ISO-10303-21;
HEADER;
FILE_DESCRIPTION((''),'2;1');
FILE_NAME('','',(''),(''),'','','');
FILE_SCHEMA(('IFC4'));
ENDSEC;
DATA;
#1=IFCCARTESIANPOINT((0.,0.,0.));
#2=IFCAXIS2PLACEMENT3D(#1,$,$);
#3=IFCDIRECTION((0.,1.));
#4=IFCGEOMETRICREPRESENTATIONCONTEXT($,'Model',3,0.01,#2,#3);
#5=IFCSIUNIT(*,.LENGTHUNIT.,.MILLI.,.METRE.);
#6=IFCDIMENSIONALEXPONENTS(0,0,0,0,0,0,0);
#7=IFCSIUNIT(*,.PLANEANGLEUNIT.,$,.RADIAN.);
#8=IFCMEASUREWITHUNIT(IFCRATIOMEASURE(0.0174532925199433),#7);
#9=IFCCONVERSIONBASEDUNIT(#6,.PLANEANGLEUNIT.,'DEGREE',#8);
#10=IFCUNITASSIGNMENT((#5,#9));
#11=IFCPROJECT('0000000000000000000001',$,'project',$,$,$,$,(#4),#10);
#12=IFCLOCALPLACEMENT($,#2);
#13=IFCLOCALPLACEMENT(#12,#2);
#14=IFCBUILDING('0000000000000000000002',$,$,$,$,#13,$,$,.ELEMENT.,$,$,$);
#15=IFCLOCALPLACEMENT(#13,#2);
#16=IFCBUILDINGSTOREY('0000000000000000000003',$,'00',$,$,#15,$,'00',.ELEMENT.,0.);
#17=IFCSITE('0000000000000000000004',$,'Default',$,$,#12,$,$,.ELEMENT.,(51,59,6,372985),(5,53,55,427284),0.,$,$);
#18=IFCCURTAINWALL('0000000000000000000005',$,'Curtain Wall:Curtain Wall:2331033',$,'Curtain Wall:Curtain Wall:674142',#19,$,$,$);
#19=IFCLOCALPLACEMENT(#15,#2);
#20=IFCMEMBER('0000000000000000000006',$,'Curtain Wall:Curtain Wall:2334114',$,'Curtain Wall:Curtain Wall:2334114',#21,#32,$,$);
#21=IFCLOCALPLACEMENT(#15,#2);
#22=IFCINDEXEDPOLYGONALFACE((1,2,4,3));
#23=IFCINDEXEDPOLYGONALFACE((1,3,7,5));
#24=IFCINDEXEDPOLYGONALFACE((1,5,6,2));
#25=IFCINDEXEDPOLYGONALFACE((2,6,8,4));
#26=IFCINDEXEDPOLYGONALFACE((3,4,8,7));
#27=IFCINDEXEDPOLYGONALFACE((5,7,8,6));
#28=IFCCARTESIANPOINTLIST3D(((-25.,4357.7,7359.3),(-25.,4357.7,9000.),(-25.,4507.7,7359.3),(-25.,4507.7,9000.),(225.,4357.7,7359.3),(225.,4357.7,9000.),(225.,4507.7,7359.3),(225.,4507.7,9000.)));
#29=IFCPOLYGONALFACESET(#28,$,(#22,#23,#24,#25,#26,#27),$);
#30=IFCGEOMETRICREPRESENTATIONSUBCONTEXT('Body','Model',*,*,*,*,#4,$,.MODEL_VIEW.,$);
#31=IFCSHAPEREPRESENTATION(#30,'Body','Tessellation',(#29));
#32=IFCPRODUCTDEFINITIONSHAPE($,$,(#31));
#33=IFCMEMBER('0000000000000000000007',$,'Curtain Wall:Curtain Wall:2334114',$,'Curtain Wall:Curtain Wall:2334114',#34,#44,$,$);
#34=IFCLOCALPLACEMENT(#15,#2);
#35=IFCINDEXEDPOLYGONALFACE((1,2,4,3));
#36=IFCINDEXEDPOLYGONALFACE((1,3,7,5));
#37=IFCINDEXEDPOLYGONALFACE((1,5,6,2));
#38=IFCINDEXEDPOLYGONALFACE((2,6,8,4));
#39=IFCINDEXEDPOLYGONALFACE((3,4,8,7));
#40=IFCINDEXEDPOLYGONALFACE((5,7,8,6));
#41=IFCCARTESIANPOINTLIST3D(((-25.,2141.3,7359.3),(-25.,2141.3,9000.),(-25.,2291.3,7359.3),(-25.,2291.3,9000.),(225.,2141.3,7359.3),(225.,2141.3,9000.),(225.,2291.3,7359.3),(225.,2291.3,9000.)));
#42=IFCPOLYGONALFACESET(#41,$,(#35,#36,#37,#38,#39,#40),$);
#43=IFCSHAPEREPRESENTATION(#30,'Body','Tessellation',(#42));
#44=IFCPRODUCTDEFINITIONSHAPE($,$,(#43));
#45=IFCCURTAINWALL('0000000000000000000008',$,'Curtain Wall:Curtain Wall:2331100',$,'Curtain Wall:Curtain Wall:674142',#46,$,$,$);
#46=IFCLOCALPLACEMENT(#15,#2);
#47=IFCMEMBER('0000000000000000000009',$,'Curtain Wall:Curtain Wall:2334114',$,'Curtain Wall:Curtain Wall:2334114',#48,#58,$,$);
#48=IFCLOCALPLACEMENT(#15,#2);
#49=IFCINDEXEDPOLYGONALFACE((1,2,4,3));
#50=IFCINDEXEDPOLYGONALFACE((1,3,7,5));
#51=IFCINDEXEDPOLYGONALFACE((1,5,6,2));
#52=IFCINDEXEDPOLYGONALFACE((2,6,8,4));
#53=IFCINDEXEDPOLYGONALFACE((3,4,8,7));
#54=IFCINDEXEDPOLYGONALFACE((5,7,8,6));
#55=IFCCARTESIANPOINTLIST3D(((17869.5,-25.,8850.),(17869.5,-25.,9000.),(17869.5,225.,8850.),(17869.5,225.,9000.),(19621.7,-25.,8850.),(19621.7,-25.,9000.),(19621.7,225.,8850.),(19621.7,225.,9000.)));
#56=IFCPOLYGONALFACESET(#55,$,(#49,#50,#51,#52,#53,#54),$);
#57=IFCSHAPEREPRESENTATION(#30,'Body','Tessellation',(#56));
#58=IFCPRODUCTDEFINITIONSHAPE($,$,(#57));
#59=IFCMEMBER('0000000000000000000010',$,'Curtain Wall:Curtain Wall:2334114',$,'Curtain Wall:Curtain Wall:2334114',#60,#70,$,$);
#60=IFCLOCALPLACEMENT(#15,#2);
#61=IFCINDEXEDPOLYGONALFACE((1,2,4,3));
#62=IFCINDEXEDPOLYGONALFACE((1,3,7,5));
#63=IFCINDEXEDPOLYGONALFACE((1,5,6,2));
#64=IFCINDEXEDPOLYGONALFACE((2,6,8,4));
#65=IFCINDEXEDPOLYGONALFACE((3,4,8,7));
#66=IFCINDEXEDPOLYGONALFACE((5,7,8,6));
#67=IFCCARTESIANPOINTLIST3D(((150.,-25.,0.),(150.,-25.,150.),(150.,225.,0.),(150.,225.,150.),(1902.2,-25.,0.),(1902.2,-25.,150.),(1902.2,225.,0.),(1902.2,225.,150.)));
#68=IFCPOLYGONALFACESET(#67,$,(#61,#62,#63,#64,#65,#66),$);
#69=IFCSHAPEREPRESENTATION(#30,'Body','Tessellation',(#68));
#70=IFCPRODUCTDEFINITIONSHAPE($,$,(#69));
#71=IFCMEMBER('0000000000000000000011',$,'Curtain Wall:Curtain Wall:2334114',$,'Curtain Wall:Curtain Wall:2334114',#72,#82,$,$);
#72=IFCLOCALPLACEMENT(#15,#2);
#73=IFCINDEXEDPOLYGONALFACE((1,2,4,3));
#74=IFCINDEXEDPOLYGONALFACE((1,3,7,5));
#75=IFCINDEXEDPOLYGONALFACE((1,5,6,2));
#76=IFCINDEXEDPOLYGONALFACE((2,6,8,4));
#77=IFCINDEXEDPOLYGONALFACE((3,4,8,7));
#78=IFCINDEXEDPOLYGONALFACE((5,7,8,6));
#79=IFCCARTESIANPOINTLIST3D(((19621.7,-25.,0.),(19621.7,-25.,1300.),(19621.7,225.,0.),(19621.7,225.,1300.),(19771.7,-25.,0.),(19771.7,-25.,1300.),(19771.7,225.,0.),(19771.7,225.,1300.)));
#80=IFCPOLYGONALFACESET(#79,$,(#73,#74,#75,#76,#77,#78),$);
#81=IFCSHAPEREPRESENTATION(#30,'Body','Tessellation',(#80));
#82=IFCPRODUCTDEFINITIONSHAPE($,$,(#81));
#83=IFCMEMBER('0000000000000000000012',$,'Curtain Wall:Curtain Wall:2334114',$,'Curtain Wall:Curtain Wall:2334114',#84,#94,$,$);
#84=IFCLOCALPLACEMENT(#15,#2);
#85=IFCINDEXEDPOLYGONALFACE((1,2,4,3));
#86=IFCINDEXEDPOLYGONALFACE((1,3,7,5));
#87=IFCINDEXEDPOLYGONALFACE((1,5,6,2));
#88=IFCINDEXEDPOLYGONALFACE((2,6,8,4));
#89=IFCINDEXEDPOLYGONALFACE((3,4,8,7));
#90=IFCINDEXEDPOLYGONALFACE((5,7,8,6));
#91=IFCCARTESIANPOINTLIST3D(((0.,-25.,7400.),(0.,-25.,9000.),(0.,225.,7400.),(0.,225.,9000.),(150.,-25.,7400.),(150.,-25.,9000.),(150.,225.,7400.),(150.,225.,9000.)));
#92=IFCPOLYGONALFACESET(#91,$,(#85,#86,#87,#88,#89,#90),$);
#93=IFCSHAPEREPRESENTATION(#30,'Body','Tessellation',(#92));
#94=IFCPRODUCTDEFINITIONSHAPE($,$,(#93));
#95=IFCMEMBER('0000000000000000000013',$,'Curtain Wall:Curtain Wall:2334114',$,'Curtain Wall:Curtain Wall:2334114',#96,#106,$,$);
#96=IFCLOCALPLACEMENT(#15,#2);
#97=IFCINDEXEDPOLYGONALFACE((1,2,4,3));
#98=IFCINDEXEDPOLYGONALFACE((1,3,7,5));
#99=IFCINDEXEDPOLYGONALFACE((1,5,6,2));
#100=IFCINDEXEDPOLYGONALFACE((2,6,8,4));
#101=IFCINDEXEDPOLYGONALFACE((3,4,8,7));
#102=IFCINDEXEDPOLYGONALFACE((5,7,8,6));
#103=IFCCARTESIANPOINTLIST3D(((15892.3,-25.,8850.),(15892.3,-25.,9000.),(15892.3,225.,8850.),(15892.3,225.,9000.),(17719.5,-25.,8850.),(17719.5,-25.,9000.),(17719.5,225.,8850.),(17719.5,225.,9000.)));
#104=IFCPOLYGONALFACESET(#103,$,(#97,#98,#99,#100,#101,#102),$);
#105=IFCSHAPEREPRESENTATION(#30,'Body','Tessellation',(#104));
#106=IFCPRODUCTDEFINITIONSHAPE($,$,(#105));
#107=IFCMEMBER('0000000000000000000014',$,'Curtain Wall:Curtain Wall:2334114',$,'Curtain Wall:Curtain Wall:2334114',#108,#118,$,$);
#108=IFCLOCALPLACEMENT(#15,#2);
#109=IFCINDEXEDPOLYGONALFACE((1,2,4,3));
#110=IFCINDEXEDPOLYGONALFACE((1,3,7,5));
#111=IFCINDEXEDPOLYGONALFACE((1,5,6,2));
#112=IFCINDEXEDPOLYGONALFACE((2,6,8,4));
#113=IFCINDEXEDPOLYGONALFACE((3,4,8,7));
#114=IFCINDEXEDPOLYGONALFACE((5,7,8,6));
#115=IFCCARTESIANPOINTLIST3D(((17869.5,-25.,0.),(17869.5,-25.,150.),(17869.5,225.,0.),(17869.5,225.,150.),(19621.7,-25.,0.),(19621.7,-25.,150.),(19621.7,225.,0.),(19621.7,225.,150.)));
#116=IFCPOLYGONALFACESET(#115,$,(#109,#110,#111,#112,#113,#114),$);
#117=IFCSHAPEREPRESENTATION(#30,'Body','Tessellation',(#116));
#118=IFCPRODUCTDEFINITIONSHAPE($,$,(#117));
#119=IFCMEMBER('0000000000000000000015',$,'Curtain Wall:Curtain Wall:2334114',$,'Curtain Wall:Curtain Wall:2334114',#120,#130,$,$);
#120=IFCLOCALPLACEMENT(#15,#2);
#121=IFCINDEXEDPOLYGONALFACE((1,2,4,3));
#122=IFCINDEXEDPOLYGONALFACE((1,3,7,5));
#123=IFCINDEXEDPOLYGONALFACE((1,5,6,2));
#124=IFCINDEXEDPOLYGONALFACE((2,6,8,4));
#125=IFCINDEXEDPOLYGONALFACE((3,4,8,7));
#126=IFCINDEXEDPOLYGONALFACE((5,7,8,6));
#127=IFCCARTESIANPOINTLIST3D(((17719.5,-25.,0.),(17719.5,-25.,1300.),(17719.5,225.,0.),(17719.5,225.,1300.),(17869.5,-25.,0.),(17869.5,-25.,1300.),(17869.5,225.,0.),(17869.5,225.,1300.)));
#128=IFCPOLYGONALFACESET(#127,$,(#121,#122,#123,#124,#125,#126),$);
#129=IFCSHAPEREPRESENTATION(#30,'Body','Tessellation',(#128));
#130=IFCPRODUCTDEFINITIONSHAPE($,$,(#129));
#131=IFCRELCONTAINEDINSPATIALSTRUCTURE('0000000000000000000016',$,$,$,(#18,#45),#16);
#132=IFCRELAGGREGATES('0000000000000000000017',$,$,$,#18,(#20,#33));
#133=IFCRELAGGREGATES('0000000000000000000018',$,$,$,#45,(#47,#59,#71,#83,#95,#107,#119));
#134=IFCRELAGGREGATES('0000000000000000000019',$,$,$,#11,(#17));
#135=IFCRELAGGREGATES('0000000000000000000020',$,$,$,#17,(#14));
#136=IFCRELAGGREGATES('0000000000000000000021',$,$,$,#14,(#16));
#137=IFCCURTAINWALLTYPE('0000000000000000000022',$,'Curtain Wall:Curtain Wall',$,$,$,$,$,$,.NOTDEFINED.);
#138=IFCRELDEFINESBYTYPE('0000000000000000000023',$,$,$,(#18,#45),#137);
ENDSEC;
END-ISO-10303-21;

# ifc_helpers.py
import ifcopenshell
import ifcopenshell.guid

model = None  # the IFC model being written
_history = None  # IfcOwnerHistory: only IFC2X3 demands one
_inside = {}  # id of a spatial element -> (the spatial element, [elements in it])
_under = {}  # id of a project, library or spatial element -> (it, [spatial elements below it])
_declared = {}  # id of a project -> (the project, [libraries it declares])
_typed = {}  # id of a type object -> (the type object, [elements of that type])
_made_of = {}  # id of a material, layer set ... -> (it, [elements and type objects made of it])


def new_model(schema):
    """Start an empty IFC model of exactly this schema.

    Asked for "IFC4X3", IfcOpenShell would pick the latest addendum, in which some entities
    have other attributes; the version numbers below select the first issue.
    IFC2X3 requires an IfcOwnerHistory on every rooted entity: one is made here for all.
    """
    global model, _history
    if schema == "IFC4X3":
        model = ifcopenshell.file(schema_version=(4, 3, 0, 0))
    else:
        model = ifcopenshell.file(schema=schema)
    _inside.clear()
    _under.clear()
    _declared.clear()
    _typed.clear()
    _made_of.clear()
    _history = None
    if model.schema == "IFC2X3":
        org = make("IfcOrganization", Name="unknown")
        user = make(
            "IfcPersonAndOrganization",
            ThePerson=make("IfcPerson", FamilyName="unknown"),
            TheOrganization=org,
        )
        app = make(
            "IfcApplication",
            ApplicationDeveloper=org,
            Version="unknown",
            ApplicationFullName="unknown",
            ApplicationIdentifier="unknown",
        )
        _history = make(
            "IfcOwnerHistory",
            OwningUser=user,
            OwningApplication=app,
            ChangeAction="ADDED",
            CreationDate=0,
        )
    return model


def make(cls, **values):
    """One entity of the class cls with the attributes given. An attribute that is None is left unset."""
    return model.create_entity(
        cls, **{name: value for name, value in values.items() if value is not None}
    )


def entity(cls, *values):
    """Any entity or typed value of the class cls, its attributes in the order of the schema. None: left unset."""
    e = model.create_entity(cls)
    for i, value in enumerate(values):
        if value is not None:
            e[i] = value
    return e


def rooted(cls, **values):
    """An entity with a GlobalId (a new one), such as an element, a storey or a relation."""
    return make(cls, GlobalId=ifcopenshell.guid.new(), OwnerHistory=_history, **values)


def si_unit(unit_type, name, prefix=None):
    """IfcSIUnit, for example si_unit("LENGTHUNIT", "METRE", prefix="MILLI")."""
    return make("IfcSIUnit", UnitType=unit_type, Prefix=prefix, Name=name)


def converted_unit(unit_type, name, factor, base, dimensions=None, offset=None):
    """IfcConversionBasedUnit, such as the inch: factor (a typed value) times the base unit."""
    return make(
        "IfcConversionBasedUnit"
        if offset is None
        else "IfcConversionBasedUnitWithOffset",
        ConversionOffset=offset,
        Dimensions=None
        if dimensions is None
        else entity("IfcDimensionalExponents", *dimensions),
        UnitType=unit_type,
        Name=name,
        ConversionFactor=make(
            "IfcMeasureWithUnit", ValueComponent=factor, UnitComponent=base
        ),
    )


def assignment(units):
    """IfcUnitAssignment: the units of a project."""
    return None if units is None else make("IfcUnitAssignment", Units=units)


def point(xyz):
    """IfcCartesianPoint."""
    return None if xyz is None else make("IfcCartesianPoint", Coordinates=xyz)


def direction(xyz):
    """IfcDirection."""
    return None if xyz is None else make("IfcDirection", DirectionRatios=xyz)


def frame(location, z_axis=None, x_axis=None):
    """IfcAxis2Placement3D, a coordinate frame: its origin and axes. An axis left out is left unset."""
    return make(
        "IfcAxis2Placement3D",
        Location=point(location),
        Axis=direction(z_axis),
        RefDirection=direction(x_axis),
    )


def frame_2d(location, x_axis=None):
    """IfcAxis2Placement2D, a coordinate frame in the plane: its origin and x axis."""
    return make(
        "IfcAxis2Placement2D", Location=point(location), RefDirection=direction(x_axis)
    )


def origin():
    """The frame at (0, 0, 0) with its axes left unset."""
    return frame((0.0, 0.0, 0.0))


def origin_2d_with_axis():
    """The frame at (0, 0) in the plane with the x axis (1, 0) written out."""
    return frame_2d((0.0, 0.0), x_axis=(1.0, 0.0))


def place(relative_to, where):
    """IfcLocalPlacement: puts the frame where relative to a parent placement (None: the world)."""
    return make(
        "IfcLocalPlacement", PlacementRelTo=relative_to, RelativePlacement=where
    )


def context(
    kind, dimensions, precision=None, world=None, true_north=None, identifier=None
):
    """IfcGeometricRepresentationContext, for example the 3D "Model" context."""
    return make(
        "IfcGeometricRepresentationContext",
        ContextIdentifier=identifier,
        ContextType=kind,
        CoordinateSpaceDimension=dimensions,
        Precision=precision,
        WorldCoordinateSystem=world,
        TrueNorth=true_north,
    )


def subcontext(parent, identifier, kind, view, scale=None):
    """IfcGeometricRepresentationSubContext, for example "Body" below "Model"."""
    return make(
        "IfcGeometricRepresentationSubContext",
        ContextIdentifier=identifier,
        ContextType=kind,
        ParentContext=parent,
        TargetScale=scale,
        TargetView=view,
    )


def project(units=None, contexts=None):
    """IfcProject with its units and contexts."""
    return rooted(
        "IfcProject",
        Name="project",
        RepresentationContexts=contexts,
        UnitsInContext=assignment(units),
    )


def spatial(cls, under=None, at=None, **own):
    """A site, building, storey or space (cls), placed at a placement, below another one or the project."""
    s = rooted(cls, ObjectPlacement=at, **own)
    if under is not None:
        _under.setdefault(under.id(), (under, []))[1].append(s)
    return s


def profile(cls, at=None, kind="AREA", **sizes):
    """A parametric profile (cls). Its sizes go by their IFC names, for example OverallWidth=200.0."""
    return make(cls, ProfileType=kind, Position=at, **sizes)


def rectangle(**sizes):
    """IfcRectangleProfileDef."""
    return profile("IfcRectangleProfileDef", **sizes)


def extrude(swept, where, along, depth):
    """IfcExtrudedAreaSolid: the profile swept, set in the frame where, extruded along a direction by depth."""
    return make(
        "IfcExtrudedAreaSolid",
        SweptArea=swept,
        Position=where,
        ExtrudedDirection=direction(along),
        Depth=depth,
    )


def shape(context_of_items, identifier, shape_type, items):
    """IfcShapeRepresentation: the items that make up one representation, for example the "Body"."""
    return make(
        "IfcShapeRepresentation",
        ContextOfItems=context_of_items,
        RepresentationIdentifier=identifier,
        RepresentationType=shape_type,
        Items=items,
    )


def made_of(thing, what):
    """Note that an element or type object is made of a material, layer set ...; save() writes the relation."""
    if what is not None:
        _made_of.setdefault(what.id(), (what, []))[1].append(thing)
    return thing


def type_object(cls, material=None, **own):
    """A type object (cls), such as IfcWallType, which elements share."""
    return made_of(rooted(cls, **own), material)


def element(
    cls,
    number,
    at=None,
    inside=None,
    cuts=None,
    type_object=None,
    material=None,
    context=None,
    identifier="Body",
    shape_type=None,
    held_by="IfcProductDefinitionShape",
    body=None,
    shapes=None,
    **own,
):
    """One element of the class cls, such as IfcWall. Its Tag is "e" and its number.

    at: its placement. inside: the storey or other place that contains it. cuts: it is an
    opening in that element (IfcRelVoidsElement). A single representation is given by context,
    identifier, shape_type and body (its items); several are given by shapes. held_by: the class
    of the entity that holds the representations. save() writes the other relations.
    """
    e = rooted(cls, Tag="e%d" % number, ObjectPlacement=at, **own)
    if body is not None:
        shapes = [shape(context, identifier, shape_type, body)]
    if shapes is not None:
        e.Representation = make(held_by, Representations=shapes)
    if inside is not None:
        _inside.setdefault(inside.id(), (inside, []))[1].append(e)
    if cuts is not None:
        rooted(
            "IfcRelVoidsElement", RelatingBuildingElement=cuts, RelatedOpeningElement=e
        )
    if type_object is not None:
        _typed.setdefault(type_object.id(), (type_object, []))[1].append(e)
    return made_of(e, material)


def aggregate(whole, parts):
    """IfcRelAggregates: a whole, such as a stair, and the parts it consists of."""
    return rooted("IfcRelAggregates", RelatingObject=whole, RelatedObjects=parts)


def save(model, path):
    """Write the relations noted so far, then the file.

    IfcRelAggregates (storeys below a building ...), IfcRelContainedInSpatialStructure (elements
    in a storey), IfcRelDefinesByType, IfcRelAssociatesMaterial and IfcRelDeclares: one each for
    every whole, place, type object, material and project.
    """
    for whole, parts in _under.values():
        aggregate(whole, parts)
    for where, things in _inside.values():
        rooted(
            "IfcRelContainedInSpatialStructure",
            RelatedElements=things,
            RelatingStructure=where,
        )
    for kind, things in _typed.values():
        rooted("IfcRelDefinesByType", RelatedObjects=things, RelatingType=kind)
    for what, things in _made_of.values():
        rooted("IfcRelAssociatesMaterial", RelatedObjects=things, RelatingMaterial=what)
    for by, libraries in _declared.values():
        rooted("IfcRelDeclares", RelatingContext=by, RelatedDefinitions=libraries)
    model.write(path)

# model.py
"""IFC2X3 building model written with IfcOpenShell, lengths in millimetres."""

from ifc_helpers import new_model, entity, si_unit, converted_unit, direction, frame, frame_2d, origin, origin_2d_with_axis, place, context, subcontext, project, spatial, rectangle, extrude, type_object, element, aggregate, save


model = new_model("IFC2X3")

# Units and contexts
model_context = context("Model", 3, precision=0.01, world=origin(), true_north=direction((0.0, 1.0)))
body_context = subcontext(model_context, "Body", "Model", "MODEL_VIEW")
ifc_project = project(units=[si_unit("LENGTHUNIT", "METRE", prefix="MILLI"), converted_unit("PLANEANGLEUNIT", "DEGREE", entity("IfcRatioMeasure", 0.0174532925199433), si_unit("PLANEANGLEUNIT", "RADIAN"), dimensions=[0, 0, 0, 0, 0, 0, 0])], contexts=[model_context])

# Site, building, storey
site_placement = place(None, origin())
site = spatial("IfcSite", under=ifc_project, at=site_placement, Name="Default", CompositionType="ELEMENT", RefLatitude=(51, 59, 6, 372985), RefLongitude=(5, 53, 55, 427284), RefElevation=0.0)
building_placement = place(site_placement, origin())
building = spatial("IfcBuilding", under=site, at=building_placement, CompositionType="ELEMENT")
storey_placement = place(building_placement, origin())
storey = spatial("IfcBuildingStorey", under=building, at=storey_placement, Name="00", LongName="00", CompositionType="ELEMENT", Elevation=0.0)

# Curtain walls, members
curtain_wall_type = type_object("IfcCurtainWallType", Name="Curtain Wall:Curtain Wall", PredefinedType="NOTDEFINED")
curtain_wall_1_placement = place(storey_placement, origin())
curtain_wall_1 = element("IfcCurtainWall", 1, at=curtain_wall_1_placement, inside=storey, type_object=curtain_wall_type, Name="Curtain Wall:Curtain Wall:2331033", ObjectType="Curtain Wall:Curtain Wall:674142")
member_1_placement = place(curtain_wall_1_placement, origin())
member_1 = element("IfcMember", 2, at=member_1_placement, Name="Curtain Wall:Curtain Wall:2334114", ObjectType="Curtain Wall:Curtain Wall:2334114", context=body_context, shape_type="SweptSolid", body=[
    extrude(rectangle(XDim=250.0, YDim=150.0, at=frame_2d((0.0, 0.0), x_axis=(1.0, 0.0))), frame((100.0, 4432.7, 7359.3), z_axis=(0.0, 0.0, 1.0), x_axis=(-1.0, 0.0, 0.0)), (0.0, 0.0, 1.0), 1640.7),
])
member_2_placement = place(curtain_wall_1_placement, origin())
member_2 = element("IfcMember", 3, at=member_2_placement, Name="Curtain Wall:Curtain Wall:2334114", ObjectType="Curtain Wall:Curtain Wall:2334114", context=body_context, shape_type="SweptSolid", body=[
    extrude(rectangle(XDim=250.0, YDim=150.0, at=frame_2d((0.0, 0.0), x_axis=(1.0, 0.0))), frame((100.0, 2216.3, 7359.3), z_axis=(0.0, 0.0, 1.0), x_axis=(-1.0, 0.0, 0.0)), (0.0, 0.0, 1.0), 1640.7),
])
aggregate(curtain_wall_1, [member_1, member_2])
curtain_wall_2_placement = place(storey_placement, origin())
curtain_wall_2 = element("IfcCurtainWall", 4, at=curtain_wall_2_placement, inside=storey, type_object=curtain_wall_type, Name="Curtain Wall:Curtain Wall:2331100", ObjectType="Curtain Wall:Curtain Wall:674142")
member_3_placement = place(curtain_wall_2_placement, origin())
member_3 = element("IfcMember", 5, at=member_3_placement, Name="Curtain Wall:Curtain Wall:2334114", ObjectType="Curtain Wall:Curtain Wall:2334114", context=body_context, shape_type="SweptSolid", body=[
    extrude(rectangle(XDim=150.0, YDim=250.0, at=frame_2d((0.0, 0.0), x_axis=(1.0, 0.0))), frame((19621.7, 100.0, 8925.0), z_axis=(-1.0, 0.0, 0.0), x_axis=(0.0, 0.0, -1.0)), (0.0, 0.0, 1.0), 1752.2),
])
member_4_placement = place(curtain_wall_2_placement, origin())
member_4 = element("IfcMember", 6, at=member_4_placement, Name="Curtain Wall:Curtain Wall:2334114", ObjectType="Curtain Wall:Curtain Wall:2334114", context=body_context, shape_type="SweptSolid", body=[
    extrude(rectangle(XDim=150.0, YDim=250.0, at=frame_2d((0.0, 0.0), x_axis=(1.0, 0.0))), frame((150.0, 100.0, 75.0), z_axis=(1.0, 0.0, 0.0), x_axis=(0.0, 0.0, -1.0)), (0.0, 0.0, 1.0), 1752.2),
])
member_5_placement = place(curtain_wall_2_placement, origin())
member_5 = element("IfcMember", 7, at=member_5_placement, Name="Curtain Wall:Curtain Wall:2334114", ObjectType="Curtain Wall:Curtain Wall:2334114", context=body_context, shape_type="SweptSolid", body=[
    extrude(rectangle(XDim=150.0, YDim=250.0, at=origin_2d_with_axis()), frame((19696.7, 100.0, 0.0), z_axis=(0.0, 0.0, 1.0), x_axis=(-1.0, 0.0, 0.0)), (0.0, 0.0, 1.0), 1300.0),
])
member_6_placement = place(curtain_wall_2_placement, origin())
member_6 = element("IfcMember", 8, at=member_6_placement, Name="Curtain Wall:Curtain Wall:2334114", ObjectType="Curtain Wall:Curtain Wall:2334114", context=body_context, shape_type="SweptSolid", body=[
    extrude(rectangle(XDim=150.0, YDim=250.0, at=origin_2d_with_axis()), frame((75.0, 100.0, 9000.0), z_axis=(0.0, 0.0, -1.0), x_axis=(-1.0, 0.0, 0.0)), (0.0, 0.0, 1.0), 1600.0),
])
member_7_placement = place(curtain_wall_2_placement, origin())
member_7 = element("IfcMember", 9, at=member_7_placement, Name="Curtain Wall:Curtain Wall:2334114", ObjectType="Curtain Wall:Curtain Wall:2334114", context=body_context, shape_type="SweptSolid", body=[
    extrude(rectangle(XDim=150.0, YDim=250.0, at=frame_2d((0.0, 0.0), x_axis=(1.0, 0.0))), frame((17719.5, 100.0, 8925.0), z_axis=(-1.0, 0.0, 0.0), x_axis=(0.0, 0.0, -1.0)), (0.0, 0.0, 1.0), 1827.2),
])
member_8_placement = place(curtain_wall_2_placement, origin())
member_8 = element("IfcMember", 10, at=member_8_placement, Name="Curtain Wall:Curtain Wall:2334114", ObjectType="Curtain Wall:Curtain Wall:2334114", context=body_context, shape_type="SweptSolid", body=[
    extrude(rectangle(XDim=150.0, YDim=250.0, at=frame_2d((0.0, 0.0), x_axis=(1.0, 0.0))), frame((17869.5, 100.0, 75.0), z_axis=(1.0, 0.0, 0.0), x_axis=(0.0, 0.0, -1.0)), (0.0, 0.0, 1.0), 1752.2),
])
member_9_placement = place(curtain_wall_2_placement, origin())
member_9 = element("IfcMember", 11, at=member_9_placement, Name="Curtain Wall:Curtain Wall:2334114", ObjectType="Curtain Wall:Curtain Wall:2334114", context=body_context, shape_type="SweptSolid", body=[
    extrude(rectangle(XDim=150.0, YDim=250.0, at=origin_2d_with_axis()), frame((17794.5, 100.0, 0.0), z_axis=(0.0, 0.0, 1.0), x_axis=(-1.0, 0.0, 0.0)), (0.0, 0.0, 1.0), 1300.0),
])
aggregate(curtain_wall_2, [member_3, member_4, member_5, member_6, member_7, member_8, member_9])

save(model, "model.ifc")
